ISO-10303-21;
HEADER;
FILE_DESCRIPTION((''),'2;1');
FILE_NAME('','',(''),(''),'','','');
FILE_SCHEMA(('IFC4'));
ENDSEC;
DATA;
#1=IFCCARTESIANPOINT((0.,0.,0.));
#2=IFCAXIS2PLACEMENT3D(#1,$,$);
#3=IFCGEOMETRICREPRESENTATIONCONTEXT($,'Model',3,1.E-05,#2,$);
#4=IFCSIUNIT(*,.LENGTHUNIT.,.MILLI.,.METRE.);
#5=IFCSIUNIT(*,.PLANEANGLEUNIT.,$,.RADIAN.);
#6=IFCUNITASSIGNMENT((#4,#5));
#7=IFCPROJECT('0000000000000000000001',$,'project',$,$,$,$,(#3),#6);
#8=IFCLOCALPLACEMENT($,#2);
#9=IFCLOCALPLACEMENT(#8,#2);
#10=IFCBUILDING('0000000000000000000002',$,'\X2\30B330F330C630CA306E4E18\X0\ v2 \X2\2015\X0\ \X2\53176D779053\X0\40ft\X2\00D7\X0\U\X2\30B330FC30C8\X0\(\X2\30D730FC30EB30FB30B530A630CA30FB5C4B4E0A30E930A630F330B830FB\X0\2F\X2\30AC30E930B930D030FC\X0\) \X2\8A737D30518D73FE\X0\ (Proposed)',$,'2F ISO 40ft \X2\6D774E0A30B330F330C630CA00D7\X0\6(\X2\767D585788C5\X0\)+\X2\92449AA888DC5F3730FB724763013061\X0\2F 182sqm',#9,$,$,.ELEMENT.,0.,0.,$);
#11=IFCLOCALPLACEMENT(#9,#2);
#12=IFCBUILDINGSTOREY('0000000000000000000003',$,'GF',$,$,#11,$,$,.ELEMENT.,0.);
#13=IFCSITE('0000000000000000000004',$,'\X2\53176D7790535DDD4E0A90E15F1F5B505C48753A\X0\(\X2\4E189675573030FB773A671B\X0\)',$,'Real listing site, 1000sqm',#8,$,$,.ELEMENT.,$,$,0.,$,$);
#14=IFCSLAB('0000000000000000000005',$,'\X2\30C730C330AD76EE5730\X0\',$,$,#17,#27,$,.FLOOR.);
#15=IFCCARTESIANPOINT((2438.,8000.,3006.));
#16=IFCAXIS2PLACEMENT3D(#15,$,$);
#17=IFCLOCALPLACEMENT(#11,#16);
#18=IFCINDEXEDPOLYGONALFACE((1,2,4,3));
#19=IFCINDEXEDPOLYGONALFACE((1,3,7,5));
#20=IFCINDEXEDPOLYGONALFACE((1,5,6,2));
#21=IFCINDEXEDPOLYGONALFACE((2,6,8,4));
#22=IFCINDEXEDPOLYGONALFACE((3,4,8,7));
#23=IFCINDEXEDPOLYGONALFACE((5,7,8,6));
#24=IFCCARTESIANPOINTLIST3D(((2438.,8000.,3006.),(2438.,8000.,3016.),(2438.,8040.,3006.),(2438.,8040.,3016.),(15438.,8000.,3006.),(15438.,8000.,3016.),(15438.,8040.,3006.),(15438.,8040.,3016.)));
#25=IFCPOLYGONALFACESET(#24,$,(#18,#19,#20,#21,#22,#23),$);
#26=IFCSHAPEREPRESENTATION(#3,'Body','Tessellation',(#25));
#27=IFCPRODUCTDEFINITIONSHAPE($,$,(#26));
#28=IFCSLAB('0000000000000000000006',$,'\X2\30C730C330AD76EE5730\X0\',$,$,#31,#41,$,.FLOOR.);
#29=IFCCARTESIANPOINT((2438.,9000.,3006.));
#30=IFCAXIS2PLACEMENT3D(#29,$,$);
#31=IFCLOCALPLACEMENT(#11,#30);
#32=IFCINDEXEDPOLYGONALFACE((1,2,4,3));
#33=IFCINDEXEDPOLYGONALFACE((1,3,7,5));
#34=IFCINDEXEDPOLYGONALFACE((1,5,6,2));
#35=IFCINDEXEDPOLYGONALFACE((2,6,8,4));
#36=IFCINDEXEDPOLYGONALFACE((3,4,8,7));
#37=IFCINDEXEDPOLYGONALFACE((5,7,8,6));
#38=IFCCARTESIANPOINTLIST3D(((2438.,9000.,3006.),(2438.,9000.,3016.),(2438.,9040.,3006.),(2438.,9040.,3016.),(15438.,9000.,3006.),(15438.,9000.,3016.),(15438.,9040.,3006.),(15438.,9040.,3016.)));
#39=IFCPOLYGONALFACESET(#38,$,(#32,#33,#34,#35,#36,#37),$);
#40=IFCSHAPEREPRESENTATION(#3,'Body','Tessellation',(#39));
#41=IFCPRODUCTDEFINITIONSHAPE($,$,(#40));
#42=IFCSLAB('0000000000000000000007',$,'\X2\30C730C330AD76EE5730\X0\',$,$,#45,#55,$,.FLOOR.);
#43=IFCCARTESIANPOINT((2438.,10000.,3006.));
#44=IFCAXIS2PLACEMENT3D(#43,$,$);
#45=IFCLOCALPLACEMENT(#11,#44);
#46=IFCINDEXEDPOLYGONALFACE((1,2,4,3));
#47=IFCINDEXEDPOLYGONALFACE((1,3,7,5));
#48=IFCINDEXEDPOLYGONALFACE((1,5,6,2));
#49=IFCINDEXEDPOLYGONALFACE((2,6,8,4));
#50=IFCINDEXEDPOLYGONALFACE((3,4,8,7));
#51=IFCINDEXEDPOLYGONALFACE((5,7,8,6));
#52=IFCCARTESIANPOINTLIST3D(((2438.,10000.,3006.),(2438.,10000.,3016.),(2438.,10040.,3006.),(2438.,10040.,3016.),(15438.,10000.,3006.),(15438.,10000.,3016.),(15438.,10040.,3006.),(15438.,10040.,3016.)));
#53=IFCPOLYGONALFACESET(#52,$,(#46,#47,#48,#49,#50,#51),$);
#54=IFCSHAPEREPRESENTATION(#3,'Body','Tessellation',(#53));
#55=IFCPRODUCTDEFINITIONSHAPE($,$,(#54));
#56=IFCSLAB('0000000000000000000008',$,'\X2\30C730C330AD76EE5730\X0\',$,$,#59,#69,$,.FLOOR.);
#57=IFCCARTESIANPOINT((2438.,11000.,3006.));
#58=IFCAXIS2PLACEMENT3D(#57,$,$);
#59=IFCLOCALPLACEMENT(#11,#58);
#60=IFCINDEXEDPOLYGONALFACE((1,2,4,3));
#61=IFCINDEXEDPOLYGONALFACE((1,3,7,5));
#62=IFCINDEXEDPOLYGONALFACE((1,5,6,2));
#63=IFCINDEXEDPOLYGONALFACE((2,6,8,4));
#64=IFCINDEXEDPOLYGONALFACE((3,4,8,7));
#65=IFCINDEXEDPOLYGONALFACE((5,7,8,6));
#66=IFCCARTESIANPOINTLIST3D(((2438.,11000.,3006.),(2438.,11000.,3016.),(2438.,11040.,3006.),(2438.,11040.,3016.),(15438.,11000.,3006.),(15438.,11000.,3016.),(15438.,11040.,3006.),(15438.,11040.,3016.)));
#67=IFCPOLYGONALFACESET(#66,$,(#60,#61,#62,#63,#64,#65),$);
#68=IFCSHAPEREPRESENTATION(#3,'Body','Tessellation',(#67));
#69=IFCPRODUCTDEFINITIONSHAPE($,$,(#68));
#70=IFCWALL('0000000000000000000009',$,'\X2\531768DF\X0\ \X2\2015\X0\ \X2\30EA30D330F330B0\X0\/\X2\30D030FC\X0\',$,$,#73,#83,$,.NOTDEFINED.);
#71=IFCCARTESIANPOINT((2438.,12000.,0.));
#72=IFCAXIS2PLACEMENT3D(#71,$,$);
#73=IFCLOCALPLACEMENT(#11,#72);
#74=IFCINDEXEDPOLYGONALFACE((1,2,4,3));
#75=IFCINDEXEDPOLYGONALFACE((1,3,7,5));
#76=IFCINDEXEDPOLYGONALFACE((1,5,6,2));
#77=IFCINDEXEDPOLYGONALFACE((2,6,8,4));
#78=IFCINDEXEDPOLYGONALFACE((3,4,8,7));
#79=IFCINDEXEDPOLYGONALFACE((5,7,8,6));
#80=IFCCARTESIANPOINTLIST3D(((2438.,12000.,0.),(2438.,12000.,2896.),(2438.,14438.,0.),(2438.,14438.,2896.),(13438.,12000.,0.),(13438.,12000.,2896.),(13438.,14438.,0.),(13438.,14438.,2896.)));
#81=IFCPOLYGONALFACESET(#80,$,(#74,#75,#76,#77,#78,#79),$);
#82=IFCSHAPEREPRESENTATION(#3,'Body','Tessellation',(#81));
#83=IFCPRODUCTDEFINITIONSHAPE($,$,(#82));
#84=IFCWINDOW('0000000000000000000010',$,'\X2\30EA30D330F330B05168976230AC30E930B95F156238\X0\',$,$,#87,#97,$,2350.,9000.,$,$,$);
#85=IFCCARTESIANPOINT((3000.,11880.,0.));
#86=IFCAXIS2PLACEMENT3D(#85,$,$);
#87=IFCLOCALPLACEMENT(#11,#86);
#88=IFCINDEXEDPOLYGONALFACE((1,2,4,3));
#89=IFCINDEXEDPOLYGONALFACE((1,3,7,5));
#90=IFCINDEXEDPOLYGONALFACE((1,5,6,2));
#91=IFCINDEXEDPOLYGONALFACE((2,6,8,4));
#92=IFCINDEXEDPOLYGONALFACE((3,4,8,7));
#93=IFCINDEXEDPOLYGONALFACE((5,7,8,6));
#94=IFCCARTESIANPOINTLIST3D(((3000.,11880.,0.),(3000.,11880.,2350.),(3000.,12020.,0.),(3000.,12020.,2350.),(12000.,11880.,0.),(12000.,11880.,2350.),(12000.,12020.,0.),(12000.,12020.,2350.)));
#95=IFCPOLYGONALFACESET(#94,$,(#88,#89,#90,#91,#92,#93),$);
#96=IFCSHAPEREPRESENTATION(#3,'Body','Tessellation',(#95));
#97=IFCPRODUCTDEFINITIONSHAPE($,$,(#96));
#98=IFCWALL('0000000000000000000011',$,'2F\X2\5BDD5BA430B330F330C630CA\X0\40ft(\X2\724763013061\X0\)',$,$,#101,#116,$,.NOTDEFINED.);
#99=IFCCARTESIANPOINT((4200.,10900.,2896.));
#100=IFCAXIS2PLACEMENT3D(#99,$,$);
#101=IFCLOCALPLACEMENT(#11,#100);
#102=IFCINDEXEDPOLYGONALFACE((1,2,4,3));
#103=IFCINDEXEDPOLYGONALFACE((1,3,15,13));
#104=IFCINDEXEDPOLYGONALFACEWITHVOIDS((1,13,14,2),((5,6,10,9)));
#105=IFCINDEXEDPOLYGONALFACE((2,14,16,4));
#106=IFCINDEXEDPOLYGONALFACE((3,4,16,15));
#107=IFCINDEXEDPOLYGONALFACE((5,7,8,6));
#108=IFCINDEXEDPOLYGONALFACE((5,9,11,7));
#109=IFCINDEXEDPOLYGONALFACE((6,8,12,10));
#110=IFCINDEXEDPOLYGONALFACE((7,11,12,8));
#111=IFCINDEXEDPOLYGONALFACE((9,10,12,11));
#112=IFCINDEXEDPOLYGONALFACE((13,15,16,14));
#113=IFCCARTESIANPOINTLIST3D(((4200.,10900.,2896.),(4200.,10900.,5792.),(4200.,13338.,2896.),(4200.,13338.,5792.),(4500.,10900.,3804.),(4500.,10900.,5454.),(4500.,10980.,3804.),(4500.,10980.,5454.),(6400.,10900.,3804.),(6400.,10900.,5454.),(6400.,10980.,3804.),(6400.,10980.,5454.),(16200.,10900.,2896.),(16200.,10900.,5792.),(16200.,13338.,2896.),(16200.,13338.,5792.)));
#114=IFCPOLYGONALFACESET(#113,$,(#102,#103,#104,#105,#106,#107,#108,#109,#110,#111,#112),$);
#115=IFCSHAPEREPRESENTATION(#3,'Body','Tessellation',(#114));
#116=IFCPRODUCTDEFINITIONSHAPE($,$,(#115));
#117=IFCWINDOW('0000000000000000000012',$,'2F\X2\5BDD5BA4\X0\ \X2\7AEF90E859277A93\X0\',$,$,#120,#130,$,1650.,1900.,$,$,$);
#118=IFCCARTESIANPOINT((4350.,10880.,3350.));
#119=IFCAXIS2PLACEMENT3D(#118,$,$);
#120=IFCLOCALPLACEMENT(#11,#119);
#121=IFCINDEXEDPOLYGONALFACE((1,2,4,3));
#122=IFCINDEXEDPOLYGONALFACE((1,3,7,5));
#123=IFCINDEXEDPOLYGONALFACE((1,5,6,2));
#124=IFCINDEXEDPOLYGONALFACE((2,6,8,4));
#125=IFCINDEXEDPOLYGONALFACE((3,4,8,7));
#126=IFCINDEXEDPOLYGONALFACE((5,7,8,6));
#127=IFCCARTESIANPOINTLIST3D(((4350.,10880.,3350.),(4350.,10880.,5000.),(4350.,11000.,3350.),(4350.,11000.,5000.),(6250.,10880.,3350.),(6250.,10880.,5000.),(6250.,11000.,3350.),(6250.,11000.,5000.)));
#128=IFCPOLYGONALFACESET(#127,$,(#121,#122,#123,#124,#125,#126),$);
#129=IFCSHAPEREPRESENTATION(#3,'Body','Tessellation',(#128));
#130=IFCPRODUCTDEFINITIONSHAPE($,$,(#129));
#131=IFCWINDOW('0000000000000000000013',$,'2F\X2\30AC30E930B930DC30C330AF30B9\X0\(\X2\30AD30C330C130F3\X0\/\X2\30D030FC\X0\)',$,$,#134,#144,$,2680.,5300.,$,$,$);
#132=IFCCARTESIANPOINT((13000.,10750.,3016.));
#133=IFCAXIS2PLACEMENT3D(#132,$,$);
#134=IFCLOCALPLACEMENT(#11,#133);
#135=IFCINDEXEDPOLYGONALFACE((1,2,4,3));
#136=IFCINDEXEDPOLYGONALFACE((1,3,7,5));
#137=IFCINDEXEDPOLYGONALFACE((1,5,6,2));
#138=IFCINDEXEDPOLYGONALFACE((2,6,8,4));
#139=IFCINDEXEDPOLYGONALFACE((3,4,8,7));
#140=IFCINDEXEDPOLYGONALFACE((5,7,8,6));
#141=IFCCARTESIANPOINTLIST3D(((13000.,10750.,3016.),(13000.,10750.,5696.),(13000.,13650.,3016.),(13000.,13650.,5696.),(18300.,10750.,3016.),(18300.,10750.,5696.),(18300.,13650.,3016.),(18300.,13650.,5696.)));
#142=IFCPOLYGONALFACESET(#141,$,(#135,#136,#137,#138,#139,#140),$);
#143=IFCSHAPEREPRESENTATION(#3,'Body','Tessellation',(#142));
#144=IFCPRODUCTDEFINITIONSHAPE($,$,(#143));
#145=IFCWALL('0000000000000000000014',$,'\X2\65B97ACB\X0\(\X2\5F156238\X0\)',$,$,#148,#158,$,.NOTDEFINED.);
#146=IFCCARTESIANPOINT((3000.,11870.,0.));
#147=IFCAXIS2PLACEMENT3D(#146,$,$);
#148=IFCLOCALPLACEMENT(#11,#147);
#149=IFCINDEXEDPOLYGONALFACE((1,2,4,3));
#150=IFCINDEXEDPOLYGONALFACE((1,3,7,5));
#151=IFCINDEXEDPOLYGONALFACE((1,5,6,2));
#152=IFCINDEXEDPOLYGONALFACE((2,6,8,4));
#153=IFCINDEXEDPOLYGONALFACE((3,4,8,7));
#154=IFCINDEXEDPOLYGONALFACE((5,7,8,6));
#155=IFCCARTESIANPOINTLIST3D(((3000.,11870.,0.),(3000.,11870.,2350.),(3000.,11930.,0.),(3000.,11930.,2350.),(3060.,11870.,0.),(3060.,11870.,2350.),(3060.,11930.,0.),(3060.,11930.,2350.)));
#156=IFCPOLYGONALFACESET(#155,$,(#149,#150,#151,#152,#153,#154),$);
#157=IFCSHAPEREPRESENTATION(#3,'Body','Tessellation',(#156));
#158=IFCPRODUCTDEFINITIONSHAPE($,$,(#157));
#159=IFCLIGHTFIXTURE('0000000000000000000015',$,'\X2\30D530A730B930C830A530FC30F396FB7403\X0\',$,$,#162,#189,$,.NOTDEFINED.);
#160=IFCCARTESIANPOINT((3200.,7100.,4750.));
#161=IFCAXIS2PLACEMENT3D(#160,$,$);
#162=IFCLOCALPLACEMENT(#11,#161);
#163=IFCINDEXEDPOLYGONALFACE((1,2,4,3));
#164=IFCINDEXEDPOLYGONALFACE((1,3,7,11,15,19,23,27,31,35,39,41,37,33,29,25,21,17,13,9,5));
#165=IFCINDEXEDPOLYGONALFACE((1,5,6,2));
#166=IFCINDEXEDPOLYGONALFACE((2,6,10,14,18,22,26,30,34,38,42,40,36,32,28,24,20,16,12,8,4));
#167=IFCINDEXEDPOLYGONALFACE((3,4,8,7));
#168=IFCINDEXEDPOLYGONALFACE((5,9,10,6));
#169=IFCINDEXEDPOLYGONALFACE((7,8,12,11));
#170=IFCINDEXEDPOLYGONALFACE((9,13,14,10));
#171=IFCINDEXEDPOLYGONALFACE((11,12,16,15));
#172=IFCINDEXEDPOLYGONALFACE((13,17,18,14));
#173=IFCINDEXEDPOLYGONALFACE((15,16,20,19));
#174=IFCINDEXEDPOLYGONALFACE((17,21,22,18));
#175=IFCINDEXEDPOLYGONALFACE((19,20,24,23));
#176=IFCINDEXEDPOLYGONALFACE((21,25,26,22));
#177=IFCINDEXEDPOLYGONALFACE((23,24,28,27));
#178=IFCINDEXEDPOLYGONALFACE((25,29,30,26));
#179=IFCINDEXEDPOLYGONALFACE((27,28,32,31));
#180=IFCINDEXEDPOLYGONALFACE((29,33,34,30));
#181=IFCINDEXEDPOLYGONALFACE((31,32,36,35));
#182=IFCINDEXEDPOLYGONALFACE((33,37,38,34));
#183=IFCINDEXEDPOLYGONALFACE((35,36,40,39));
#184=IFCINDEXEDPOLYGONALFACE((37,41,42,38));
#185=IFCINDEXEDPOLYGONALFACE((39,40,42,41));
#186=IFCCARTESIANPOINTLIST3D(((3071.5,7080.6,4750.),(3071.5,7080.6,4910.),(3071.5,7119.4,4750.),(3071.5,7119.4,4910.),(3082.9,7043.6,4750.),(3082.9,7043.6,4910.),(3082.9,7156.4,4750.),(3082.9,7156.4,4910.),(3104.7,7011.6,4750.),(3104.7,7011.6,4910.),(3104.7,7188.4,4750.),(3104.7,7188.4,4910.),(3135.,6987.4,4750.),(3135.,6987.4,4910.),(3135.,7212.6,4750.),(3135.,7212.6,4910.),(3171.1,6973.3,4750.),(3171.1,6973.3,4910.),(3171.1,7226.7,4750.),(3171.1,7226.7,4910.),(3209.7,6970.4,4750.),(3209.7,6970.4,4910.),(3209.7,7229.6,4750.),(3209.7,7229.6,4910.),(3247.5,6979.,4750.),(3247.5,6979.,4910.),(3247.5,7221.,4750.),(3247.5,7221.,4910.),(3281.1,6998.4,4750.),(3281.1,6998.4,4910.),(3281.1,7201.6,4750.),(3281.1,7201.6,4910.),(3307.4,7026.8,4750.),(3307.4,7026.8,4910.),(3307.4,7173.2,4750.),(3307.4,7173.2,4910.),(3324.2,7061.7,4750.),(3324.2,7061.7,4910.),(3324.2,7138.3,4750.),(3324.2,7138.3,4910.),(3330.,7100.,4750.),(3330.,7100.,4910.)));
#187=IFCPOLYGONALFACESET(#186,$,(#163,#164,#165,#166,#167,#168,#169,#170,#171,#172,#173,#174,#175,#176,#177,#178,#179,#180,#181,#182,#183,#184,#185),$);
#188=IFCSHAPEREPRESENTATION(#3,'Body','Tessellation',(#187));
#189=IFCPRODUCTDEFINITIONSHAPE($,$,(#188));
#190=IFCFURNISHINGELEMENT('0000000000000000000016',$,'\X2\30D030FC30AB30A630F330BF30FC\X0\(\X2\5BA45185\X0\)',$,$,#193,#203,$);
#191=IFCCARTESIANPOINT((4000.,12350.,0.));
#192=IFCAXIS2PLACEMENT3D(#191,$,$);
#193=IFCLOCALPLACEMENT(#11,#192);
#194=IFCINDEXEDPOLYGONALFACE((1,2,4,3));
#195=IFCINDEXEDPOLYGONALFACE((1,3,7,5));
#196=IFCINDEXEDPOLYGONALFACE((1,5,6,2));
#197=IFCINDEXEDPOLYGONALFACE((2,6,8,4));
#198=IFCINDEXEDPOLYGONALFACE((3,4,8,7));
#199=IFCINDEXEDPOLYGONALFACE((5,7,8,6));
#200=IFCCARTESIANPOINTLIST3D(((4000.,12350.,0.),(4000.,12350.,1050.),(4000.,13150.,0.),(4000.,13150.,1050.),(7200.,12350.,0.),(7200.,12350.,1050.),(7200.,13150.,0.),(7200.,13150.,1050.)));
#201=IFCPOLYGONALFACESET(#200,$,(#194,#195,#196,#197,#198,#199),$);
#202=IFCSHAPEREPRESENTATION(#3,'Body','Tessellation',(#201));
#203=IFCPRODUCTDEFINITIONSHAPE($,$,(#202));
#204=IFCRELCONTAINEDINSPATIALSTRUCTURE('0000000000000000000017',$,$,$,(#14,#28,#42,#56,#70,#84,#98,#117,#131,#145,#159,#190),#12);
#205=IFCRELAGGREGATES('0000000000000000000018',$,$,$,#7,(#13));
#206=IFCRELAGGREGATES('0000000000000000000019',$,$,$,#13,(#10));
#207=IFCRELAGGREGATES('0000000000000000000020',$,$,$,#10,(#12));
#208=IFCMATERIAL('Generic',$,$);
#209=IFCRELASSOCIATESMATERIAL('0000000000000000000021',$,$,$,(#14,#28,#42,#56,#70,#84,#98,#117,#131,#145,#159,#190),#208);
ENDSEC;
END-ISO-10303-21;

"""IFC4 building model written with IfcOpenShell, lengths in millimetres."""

from ifc_helpers import new_model, si_unit, frame, frame_2d, origin, origin_2d, place, context, project, spatial, rectangle, circle, extrude, material, element, fill, save


model = new_model("IFC4")

# Units and contexts
model_context = context("Model", 3, precision=1e-05, world=origin())
ifc_project = project(units=[si_unit("LENGTHUNIT", "METRE", prefix="MILLI"), si_unit("PLANEANGLEUNIT", "RADIAN")], contexts=[model_context])

# Site, building, storey
site_placement = place(None, origin())
site = spatial("IfcSite", under=ifc_project, at=site_placement, Name="北海道川上郡弟子屈町(丘陵地・眺望)", ObjectType="Real listing site, 1000sqm", CompositionType="ELEMENT", RefElevation=0.0)
building_placement = place(site_placement, origin())
building = spatial("IfcBuilding", under=site, at=building_placement, Name="コンテナの丘 v2 ― 北海道40ft×Uコート(プール・サウナ・屋上ラウンジ・2Fガラスバー) 詳細再現 (Proposed)", ObjectType="2F ISO 40ft 海上コンテナ×6(白塗装)+鉄骨補強・片持ち2F 182sqm", CompositionType="ELEMENT", ElevationOfRefHeight=0.0, ElevationOfTerrain=0.0)
storey_placement = place(building_placement, origin())
storey = spatial("IfcBuildingStorey", under=building, at=storey_placement, Name="GF", CompositionType="ELEMENT", Elevation=0.0)

# Slabs
ifc_material = material(Name="Generic")
slab_1_placement = place(storey_placement, frame((2438.0, 8000.0, 3006.0)))
element("IfcSlab", 1, at=slab_1_placement, inside=storey, material=ifc_material, Name="デッキ目地", PredefinedType="FLOOR", context=model_context, shape_type="SweptSolid", body=[
    extrude(rectangle(XDim=13000.0, YDim=40.0, at=frame_2d((6500.0, 20.0))), frame((2438.0, 8000.0, 3006.0)), (0.0, 0.0, 1.0), 10.0),
])
slab_2_placement = place(storey_placement, frame((2438.0, 9000.0, 3006.0)))
element("IfcSlab", 2, at=slab_2_placement, inside=storey, material=ifc_material, Name="デッキ目地", PredefinedType="FLOOR", context=model_context, shape_type="SweptSolid", body=[
    extrude(rectangle(XDim=13000.0, YDim=40.0, at=frame_2d((6500.0, 20.0))), frame((2438.0, 9000.0, 3006.0)), (0.0, 0.0, 1.0), 10.0),
])
slab_3_placement = place(storey_placement, frame((2438.0, 10000.0, 3006.0)))
element("IfcSlab", 3, at=slab_3_placement, inside=storey, material=ifc_material, Name="デッキ目地", PredefinedType="FLOOR", context=model_context, shape_type="SweptSolid", body=[
    extrude(rectangle(XDim=13000.0, YDim=40.0, at=frame_2d((6500.0, 20.0))), frame((2438.0, 10000.0, 3006.0)), (0.0, 0.0, 1.0), 10.0),
])
slab_4_placement = place(storey_placement, frame((2438.0, 11000.0, 3006.0)))
element("IfcSlab", 4, at=slab_4_placement, inside=storey, material=ifc_material, Name="デッキ目地", PredefinedType="FLOOR", context=model_context, shape_type="SweptSolid", body=[
    extrude(rectangle(XDim=13000.0, YDim=40.0, at=frame_2d((6500.0, 20.0))), frame((2438.0, 11000.0, 3006.0)), (0.0, 0.0, 1.0), 10.0),
])

# Wall, opening, window
wall_1_placement = place(storey_placement, frame((2438.0, 12000.0, 0.0)))
wall_1 = element("IfcWall", 5, at=wall_1_placement, inside=storey, material=ifc_material, Name="北棟 ― リビング/バー", PredefinedType="NOTDEFINED", context=model_context, shape_type="SweptSolid", body=[
    extrude(rectangle(XDim=11000.0, YDim=2438.0, at=frame_2d((5500.0, 1219.0))), frame((2438.0, 12000.0, 0.0)), (0.0, 0.0, 1.0), 2896.0),
])
opening_1_placement = place(storey_placement, frame((3000.0, 11880.0, 0.0)))
opening_1 = element("IfcOpeningElement", 6, at=opening_1_placement, cuts=wall_1, PredefinedType="NOTDEFINED", context=model_context, shape_type="SweptSolid", body=[
    extrude(rectangle(XDim=9000.0, YDim=140.0, at=frame_2d((4500.0, 70.0))), frame((3000.0, 11880.0, 0.0)), (0.0, 0.0, 1.0), 2350.0),
])
window_1_placement = place(storey_placement, frame((3000.0, 11880.0, 0.0)))
window_1 = element("IfcWindow", 7, at=window_1_placement, inside=storey, material=ifc_material, Name="リビング全面ガラス引戸", OverallHeight=2350.0, OverallWidth=9000.0, context=model_context, shape_type="SweptSolid", body=[
    extrude(rectangle(XDim=9000.0, YDim=140.0, at=frame_2d((4500.0, 70.0))), frame((3000.0, 11880.0, 0.0)), (0.0, 0.0, 1.0), 2350.0),
])
fill(opening_1, window_1)

# Wall, openings, windows
wall_2_placement = place(storey_placement, frame((4200.0, 10900.0, 2896.0)))
wall_2 = element("IfcWall", 8, at=wall_2_placement, inside=storey, material=ifc_material, Name="2F寝室コンテナ40ft(片持ち)", PredefinedType="NOTDEFINED", context=model_context, shape_type="SweptSolid", body=[
    extrude(rectangle(XDim=12000.0, YDim=2438.0, at=frame_2d((6000.0, 1219.0))), frame((4200.0, 10900.0, 2896.0)), (0.0, 0.0, 1.0), 2896.0),
])
opening_2_placement = place(storey_placement, frame((4350.0, 10880.0, 3350.0)))
opening_2 = element("IfcOpeningElement", 9, at=opening_2_placement, cuts=wall_2, PredefinedType="NOTDEFINED", context=model_context, shape_type="SweptSolid", body=[
    extrude(rectangle(XDim=1900.0, YDim=120.0, at=frame_2d((950.0, 60.0))), frame((4350.0, 10880.0, 3350.0)), (0.0, 0.0, 1.0), 1650.0),
])
opening_3_placement = place(storey_placement, frame((13000.0, 10750.0, 3016.0)))
opening_3 = element("IfcOpeningElement", 10, at=opening_3_placement, cuts=wall_2, PredefinedType="NOTDEFINED", context=model_context, shape_type="SweptSolid", body=[
    extrude(rectangle(XDim=5300.0, YDim=2900.0, at=frame_2d((2650.0, 1450.0))), frame((13000.0, 10750.0, 3016.0)), (0.0, 0.0, 1.0), 2680.0),
])
window_2_placement = place(storey_placement, frame((4350.0, 10880.0, 3350.0)))
window_2 = element("IfcWindow", 11, at=window_2_placement, inside=storey, material=ifc_material, Name="2F寝室 端部大窓", OverallHeight=1650.0, OverallWidth=1900.0, context=model_context, shape_type="SweptSolid", body=[
    extrude(rectangle(XDim=1900.0, YDim=120.0, at=frame_2d((950.0, 60.0))), frame((4350.0, 10880.0, 3350.0)), (0.0, 0.0, 1.0), 1650.0),
])
fill(opening_2, window_2)
window_3_placement = place(storey_placement, frame((13000.0, 10750.0, 3016.0)))
window_3 = element("IfcWindow", 12, at=window_3_placement, inside=storey, material=ifc_material, Name="2Fガラスボックス(キッチン/バー)", OverallHeight=2680.0, OverallWidth=5300.0, context=model_context, shape_type="SweptSolid", body=[
    extrude(rectangle(XDim=5300.0, YDim=2900.0, at=frame_2d((2650.0, 1450.0))), frame((13000.0, 10750.0, 3016.0)), (0.0, 0.0, 1.0), 2680.0),
])
fill(opening_3, window_3)

# Wall
wall_3_placement = place(storey_placement, frame((3000.0, 11870.0, 0.0)))
element("IfcWall", 13, at=wall_3_placement, inside=storey, material=ifc_material, Name="方立(引戸)", PredefinedType="NOTDEFINED", context=model_context, shape_type="SweptSolid", body=[
    extrude(rectangle(XDim=60.0, YDim=60.0, at=frame_2d((30.0, 30.0))), frame((3000.0, 11870.0, 0.0)), (0.0, 0.0, 1.0), 2350.0),
])

# Light fixture
light_fixture_placement = place(storey_placement, frame((3200.0, 7100.0, 4750.0)))
element("IfcLightFixture", 14, at=light_fixture_placement, inside=storey, material=ifc_material, Name="フェストゥーン電球", PredefinedType="NOTDEFINED", context=model_context, shape_type="SweptSolid", body=[
    extrude(circle(Radius=130.0, at=origin_2d()), frame((3200.0, 7100.0, 4750.0)), (0.0, 0.0, 1.0), 160.0),
])

# Furnishing element
furnishing_1_placement = place(storey_placement, frame((4000.0, 12350.0, 0.0)))
element("IfcFurnishingElement", 15, at=furnishing_1_placement, inside=storey, material=ifc_material, Name="バーカウンター(室内)", context=model_context, shape_type="SweptSolid", body=[
    extrude(rectangle(XDim=3200.0, YDim=800.0, at=frame_2d((1600.0, 400.0))), frame((4000.0, 12350.0, 0.0)), (0.0, 0.0, 1.0), 1050.0),
])

save(model, "model.ifc")
